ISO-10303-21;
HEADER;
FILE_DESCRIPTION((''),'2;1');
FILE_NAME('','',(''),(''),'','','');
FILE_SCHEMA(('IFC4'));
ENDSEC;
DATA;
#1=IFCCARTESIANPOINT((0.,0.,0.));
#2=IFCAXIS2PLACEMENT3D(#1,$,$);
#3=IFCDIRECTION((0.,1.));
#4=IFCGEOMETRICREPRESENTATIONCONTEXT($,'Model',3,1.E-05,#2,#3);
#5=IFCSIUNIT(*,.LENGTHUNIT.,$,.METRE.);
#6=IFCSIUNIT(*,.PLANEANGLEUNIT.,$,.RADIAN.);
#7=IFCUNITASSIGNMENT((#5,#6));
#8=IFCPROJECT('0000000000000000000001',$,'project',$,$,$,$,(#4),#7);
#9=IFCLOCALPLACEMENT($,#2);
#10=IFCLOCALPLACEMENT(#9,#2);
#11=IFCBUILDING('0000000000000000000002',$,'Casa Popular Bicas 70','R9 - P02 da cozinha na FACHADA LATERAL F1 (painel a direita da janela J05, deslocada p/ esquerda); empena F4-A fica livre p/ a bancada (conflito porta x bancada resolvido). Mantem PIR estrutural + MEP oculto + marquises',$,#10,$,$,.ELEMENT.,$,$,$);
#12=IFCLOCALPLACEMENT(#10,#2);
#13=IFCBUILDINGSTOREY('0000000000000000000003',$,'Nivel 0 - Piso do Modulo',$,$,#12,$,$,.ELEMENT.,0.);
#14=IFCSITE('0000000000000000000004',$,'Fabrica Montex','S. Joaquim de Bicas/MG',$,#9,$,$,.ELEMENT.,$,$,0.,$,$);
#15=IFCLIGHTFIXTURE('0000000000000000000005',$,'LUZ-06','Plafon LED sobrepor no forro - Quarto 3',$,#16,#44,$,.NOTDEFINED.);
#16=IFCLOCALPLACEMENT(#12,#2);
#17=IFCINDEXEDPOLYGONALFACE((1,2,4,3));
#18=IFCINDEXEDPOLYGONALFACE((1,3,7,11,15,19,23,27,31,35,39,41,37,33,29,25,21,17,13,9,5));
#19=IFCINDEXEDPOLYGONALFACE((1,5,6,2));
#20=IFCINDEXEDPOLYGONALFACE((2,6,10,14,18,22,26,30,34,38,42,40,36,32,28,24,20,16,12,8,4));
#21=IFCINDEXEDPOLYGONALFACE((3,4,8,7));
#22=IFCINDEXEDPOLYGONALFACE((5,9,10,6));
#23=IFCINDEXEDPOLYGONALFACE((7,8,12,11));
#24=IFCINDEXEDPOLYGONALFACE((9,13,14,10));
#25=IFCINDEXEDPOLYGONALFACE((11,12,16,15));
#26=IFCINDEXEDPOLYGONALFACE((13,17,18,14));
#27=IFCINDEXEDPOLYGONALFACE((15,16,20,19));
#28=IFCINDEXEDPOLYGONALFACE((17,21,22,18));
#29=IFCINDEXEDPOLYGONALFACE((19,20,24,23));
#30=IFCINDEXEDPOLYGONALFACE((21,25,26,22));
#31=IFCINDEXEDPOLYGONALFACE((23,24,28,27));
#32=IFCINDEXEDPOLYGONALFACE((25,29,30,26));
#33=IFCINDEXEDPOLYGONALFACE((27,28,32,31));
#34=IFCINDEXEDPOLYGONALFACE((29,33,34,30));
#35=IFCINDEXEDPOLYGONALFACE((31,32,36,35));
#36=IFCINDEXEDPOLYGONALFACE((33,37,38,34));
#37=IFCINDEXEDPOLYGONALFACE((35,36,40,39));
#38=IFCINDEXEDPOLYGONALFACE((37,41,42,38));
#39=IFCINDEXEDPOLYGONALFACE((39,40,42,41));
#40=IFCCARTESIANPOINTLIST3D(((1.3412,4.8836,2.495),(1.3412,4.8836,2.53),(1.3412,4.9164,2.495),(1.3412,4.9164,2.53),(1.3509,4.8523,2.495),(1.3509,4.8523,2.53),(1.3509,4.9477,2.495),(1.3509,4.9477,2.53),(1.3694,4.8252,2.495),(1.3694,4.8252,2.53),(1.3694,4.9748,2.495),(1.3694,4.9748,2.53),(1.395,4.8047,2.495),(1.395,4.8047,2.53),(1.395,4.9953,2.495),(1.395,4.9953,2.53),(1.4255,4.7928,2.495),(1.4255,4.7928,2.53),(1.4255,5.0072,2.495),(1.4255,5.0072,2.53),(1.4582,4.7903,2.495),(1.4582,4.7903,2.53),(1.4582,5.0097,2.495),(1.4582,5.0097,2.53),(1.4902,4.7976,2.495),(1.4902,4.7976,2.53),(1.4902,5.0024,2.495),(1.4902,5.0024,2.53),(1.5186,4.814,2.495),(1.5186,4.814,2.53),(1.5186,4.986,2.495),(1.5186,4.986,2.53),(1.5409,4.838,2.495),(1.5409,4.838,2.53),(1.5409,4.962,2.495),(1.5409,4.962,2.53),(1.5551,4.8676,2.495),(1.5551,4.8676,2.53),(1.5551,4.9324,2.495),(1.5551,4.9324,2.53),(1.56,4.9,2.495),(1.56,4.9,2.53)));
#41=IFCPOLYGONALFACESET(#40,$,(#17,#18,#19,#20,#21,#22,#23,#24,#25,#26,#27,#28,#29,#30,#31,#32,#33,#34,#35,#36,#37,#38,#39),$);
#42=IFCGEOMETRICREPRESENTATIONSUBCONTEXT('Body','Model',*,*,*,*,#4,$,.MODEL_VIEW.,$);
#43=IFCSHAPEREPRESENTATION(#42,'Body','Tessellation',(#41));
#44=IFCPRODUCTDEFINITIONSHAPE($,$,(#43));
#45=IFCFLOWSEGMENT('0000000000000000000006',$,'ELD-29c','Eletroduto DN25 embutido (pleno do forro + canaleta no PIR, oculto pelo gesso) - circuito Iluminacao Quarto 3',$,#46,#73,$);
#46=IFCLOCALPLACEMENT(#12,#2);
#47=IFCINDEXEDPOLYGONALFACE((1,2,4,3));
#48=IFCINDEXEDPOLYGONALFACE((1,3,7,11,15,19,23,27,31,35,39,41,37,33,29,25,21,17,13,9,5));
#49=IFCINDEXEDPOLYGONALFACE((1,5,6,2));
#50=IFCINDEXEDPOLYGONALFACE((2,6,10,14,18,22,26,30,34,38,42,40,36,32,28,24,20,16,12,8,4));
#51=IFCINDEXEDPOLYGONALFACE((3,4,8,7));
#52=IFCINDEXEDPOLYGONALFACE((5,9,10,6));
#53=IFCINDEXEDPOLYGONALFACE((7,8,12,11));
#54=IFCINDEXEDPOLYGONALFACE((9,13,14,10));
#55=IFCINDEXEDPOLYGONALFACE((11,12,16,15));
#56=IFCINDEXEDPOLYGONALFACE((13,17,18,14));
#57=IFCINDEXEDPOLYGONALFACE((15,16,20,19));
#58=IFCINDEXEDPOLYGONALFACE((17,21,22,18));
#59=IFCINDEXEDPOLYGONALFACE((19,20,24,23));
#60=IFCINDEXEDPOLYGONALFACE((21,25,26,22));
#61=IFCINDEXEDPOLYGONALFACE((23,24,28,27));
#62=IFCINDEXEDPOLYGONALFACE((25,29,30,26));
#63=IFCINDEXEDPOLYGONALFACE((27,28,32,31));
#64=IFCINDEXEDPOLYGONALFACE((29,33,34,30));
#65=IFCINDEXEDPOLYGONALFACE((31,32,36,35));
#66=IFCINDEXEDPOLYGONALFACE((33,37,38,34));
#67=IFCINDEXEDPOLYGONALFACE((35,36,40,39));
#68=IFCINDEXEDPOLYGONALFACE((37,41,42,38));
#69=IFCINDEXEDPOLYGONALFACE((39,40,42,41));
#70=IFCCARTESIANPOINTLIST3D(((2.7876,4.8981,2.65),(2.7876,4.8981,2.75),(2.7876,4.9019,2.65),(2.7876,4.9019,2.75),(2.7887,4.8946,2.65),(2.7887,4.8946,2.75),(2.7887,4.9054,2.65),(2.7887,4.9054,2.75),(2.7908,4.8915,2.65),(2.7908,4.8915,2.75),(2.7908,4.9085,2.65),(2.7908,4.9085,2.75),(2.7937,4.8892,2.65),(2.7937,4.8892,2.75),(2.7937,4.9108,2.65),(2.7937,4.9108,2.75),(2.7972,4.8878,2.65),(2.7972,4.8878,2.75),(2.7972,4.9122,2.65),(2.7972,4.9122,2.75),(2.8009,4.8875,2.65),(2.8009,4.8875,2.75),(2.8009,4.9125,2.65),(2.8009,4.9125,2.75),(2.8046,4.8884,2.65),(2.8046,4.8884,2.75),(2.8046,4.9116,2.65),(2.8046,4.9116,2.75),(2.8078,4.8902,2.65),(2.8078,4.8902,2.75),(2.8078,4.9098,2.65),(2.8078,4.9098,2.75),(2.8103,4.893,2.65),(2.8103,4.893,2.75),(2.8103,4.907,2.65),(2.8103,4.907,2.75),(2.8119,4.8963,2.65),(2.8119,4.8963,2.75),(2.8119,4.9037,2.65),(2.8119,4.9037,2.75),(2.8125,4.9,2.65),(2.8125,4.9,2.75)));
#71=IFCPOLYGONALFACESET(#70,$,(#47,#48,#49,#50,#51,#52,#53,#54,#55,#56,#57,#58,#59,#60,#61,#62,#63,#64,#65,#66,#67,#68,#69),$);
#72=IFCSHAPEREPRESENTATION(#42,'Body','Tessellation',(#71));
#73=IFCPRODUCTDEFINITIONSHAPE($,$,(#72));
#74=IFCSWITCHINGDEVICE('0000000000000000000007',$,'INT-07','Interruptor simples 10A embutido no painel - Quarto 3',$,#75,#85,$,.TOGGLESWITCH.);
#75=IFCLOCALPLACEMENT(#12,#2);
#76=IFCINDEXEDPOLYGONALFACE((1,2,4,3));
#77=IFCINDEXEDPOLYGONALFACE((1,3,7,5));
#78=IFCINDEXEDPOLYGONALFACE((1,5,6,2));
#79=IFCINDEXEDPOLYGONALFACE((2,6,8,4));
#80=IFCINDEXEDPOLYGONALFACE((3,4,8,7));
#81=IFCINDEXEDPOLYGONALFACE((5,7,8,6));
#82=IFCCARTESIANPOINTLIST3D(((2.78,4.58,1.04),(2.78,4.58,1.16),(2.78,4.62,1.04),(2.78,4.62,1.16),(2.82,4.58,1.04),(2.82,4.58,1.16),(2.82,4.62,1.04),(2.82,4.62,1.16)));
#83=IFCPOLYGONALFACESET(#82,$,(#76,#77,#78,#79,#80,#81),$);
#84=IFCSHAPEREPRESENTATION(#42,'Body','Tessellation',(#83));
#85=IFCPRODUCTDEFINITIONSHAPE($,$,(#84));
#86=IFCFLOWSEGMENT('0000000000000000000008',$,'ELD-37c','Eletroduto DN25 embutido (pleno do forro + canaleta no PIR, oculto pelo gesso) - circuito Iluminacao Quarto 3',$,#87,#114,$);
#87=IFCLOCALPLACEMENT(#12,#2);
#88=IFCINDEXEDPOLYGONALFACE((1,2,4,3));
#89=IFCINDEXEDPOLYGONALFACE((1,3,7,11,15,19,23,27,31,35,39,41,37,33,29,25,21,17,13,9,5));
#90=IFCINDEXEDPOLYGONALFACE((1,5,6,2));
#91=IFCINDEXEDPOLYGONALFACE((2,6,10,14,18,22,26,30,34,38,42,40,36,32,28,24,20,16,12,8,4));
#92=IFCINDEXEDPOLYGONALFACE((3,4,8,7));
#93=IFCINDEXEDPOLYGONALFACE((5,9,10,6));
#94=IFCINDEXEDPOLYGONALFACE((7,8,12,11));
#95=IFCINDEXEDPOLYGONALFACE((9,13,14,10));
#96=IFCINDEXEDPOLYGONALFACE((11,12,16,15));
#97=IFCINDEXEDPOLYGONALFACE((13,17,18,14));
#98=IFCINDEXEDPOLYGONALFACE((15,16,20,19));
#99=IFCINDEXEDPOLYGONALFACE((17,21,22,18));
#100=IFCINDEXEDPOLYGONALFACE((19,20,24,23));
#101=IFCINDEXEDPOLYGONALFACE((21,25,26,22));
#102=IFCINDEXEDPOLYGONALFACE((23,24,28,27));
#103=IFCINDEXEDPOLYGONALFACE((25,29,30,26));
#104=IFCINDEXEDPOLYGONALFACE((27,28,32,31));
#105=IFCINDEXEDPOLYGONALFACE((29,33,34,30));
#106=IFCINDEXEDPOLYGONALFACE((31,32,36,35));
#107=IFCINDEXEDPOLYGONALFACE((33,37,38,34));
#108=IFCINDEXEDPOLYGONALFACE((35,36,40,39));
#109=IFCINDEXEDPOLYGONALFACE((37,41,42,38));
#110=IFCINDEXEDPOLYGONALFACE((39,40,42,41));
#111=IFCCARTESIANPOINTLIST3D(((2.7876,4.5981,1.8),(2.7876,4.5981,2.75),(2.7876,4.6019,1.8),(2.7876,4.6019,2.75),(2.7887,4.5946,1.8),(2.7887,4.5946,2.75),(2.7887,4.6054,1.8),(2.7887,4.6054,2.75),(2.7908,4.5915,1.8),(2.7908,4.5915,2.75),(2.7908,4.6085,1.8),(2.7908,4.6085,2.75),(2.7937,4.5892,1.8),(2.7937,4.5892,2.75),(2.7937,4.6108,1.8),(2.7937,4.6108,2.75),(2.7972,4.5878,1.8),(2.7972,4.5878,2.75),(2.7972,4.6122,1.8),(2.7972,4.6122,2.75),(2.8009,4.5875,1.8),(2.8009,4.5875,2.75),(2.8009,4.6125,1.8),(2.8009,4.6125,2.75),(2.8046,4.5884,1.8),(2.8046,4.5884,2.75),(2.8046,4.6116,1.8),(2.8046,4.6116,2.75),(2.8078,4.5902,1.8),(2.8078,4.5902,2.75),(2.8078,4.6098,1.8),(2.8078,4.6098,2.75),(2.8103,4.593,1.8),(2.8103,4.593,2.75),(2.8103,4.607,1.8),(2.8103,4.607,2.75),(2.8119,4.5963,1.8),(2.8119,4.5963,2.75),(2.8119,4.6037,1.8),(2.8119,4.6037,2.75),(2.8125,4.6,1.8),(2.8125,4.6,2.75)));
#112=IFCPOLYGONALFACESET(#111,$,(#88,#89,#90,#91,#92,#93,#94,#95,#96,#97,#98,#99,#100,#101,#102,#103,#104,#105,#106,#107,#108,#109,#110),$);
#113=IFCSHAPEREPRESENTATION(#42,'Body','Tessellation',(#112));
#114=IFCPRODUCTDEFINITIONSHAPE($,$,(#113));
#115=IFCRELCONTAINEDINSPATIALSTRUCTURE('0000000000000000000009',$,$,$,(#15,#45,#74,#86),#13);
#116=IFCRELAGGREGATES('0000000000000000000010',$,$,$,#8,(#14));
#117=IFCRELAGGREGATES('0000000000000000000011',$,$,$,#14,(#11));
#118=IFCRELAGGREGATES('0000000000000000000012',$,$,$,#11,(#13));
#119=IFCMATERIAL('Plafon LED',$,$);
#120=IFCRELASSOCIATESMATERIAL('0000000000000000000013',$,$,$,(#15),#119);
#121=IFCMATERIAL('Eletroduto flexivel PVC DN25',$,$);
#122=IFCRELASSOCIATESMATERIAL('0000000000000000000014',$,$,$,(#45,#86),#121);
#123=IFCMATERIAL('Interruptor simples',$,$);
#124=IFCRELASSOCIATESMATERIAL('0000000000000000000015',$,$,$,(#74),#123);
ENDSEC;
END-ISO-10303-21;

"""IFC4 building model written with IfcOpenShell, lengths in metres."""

from ifc_helpers import new_model, si_unit, direction, frame, frame_2d, origin, origin_2d, place, context, subcontext, project, spatial, rectangle, circle, extrude, material, element, save


model = new_model("IFC4")

# Units and contexts
model_context = context("Model", 3, precision=1e-05, world=origin(), true_north=direction((0.0, 1.0)))
body_context = subcontext(model_context, "Body", "Model", "MODEL_VIEW")
ifc_project = project(units=[si_unit("LENGTHUNIT", "METRE"), si_unit("PLANEANGLEUNIT", "RADIAN")], contexts=[model_context])

# Site, building, storey
site_placement = place(None, origin())
site = spatial("IfcSite", under=ifc_project, at=site_placement, Name="Fabrica Montex", Description="S. Joaquim de Bicas/MG", CompositionType="ELEMENT", RefElevation=0.0)
building_placement = place(site_placement, origin())
building = spatial("IfcBuilding", under=site, at=building_placement, Name="Casa Popular Bicas 70", Description="R9 - P02 da cozinha na FACHADA LATERAL F1 (painel a direita da janela J05, deslocada p/ esquerda); empena F4-A fica livre p/ a bancada (conflito porta x bancada resolvido). Mantem PIR estrutural + MEP oculto + marquises", CompositionType="ELEMENT")
storey_placement = place(building_placement, origin())
storey = spatial("IfcBuildingStorey", under=building, at=storey_placement, Name="Nivel 0 - Piso do Modulo", CompositionType="ELEMENT", Elevation=0.0)

# Shared definitions
ifc_material_1 = material(Name="Eletroduto flexivel PVC DN25")

# Light fixture
ifc_material_2 = material(Name="Plafon LED")
light_fixture_placement = place(storey_placement, frame((1.45, 4.9, 2.495)))
element("IfcLightFixture", 1, at=light_fixture_placement, inside=storey, material=ifc_material_2, Name="LUZ-06", Description="Plafon LED sobrepor no forro - Quarto 3", PredefinedType="NOTDEFINED", context=body_context, shape_type="SweptSolid", body=[
    extrude(circle(Radius=0.11, at=origin_2d()), origin(), (0.0, 0.0, 1.0), 0.035),
])

# Flow segment
flow_segment_1_placement = place(storey_placement, frame((2.8, 4.9, 2.75), z_axis=(0.0, 0.0, -1.0), x_axis=(1.0, 0.0, 0.0)))
element("IfcFlowSegment", 2, at=flow_segment_1_placement, inside=storey, material=ifc_material_1, Name="ELD-29c", Description="Eletroduto DN25 embutido (pleno do forro + canaleta no PIR, oculto pelo gesso) - circuito Iluminacao Quarto 3", context=body_context, shape_type="SweptSolid", body=[
    extrude(circle(Radius=0.0125, at=origin_2d()), origin(), (0.0, 0.0, 1.0), 0.1),
])

# Switching device
ifc_material_3 = material(Name="Interruptor simples")
switching_device_placement = place(storey_placement, frame((2.78, 4.58, 1.04)))
element("IfcSwitchingDevice", 3, at=switching_device_placement, inside=storey, material=ifc_material_3, Name="INT-07", Description="Interruptor simples 10A embutido no painel - Quarto 3", PredefinedType="TOGGLESWITCH", context=body_context, shape_type="SweptSolid", body=[
    extrude(rectangle(XDim=0.04, YDim=0.04, at=frame_2d((0.02, 0.02))), origin(), (0.0, 0.0, 1.0), 0.12),
])

# Flow segment
flow_segment_2_placement = place(storey_placement, frame((2.8, 4.6, 2.75), z_axis=(0.0, 0.0, -1.0), x_axis=(1.0, 0.0, 0.0)))
element("IfcFlowSegment", 4, at=flow_segment_2_placement, inside=storey, material=ifc_material_1, Name="ELD-37c", Description="Eletroduto DN25 embutido (pleno do forro + canaleta no PIR, oculto pelo gesso) - circuito Iluminacao Quarto 3", context=body_context, shape_type="SweptSolid", body=[
    extrude(circle(Radius=0.0125, at=origin_2d()), origin(), (0.0, 0.0, 1.0), 0.95),
])

save(model, "model.ifc")
